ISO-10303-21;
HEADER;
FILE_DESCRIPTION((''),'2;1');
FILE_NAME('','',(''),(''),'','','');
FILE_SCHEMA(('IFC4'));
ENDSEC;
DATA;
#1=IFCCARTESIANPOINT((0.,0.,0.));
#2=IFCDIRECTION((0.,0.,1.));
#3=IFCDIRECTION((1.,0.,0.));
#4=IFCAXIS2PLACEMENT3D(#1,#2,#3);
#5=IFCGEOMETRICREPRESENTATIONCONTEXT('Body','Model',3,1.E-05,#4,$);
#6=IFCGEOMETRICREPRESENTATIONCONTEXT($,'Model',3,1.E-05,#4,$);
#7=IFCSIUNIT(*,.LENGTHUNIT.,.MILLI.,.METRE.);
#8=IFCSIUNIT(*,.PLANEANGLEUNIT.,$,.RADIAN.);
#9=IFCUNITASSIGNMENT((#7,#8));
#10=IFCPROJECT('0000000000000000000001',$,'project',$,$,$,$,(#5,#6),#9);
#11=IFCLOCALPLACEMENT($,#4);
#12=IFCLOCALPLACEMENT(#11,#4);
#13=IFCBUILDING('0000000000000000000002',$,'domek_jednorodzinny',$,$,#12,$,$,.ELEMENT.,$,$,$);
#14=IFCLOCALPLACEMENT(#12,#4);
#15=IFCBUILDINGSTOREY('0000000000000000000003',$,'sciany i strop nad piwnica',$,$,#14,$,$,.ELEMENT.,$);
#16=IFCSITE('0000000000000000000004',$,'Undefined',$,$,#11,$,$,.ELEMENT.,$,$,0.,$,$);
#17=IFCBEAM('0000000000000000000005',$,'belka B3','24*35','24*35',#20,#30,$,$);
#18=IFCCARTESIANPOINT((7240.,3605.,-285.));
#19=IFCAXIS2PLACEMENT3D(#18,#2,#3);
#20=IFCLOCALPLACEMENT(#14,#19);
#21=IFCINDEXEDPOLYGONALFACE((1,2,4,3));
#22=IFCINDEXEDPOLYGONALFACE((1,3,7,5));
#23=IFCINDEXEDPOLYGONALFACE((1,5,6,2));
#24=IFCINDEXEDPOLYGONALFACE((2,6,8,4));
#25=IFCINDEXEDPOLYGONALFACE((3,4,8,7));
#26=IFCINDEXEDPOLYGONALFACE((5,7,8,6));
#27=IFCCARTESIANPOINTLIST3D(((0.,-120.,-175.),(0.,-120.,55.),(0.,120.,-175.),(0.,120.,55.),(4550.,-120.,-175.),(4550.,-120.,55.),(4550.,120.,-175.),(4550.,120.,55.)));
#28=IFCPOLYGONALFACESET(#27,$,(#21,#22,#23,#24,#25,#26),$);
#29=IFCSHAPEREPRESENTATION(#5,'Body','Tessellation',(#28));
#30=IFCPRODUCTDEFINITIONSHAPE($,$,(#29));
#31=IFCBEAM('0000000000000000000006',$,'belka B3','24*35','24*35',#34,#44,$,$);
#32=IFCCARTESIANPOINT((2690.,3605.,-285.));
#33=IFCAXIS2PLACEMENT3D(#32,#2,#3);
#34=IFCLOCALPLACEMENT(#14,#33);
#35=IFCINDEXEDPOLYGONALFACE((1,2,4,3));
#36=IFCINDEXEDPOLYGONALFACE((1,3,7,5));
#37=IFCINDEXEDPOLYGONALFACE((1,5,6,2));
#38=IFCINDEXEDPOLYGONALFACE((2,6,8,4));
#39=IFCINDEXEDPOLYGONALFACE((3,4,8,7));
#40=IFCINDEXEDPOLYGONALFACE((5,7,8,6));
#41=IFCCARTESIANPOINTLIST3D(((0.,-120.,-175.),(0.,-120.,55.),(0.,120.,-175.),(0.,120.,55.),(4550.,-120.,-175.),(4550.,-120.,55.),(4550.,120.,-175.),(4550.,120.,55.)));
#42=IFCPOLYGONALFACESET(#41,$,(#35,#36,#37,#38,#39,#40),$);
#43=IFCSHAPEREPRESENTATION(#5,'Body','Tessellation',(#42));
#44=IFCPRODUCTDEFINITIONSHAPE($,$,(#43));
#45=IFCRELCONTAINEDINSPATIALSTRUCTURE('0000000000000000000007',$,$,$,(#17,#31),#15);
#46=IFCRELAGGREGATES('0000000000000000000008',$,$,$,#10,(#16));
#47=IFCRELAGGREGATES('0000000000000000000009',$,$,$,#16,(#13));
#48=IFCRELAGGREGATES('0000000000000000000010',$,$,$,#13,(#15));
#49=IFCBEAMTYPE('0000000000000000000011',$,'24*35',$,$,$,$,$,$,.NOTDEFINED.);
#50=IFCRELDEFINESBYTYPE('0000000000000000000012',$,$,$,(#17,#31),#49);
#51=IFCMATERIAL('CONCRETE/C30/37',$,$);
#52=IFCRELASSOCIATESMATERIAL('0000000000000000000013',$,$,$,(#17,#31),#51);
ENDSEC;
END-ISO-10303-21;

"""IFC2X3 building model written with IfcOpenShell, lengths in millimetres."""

from ifc_helpers import new_model, si_unit, frame, origin_with_axes, origin_2d_with_axis, place, context, project, spatial, rectangle, extrude, clip, halfspace, material, type_object, element, save


model = new_model("IFC2X3")

# Units and contexts
model_context_1 = context("Model", 3, precision=1e-05, world=origin_with_axes(), identifier="Body")
model_context_2 = context("Model", 3, precision=1e-05, world=origin_with_axes())
ifc_project = project(units=[si_unit("LENGTHUNIT", "METRE", prefix="MILLI"), si_unit("PLANEANGLEUNIT", "RADIAN")], contexts=[model_context_1, model_context_2])

# Site, building, storey
site_placement = place(None, origin_with_axes())
site = spatial("IfcSite", under=ifc_project, at=site_placement, Name="Undefined", CompositionType="ELEMENT", RefElevation=0.0)
building_placement = place(site_placement, origin_with_axes())
building = spatial("IfcBuilding", under=site, at=building_placement, Name="domek_jednorodzinny", CompositionType="ELEMENT")
storey_placement = place(building_placement, origin_with_axes())
storey = spatial("IfcBuildingStorey", under=building, at=storey_placement, Name="sciany i strop nad piwnica", CompositionType="ELEMENT")

# Shared definitions
ifc_material_1 = material(Name="CONCRETE/C30/37")

# Beams
beam_type_1 = type_object("IfcBeamType", Name="24*35", PredefinedType="NOTDEFINED")
beam_1_placement = place(storey_placement, frame((7240.0, 3605.0, -285.0), z_axis=(0.0, 0.0, 1.0), x_axis=(1.0, 0.0, 0.0)))
element("IfcBeam", 1, at=beam_1_placement, inside=storey, type_object=beam_type_1, material=ifc_material_1, Name="belka B3", Description="24*35", ObjectType="24*35", context=model_context_1, shape_type="Clipping", body=[
    clip(extrude(rectangle(XDim=240.0, YDim=350.0, at=origin_2d_with_axis()), frame((4550.0, 0.0, 0.0), z_axis=(-1.0, 0.0, 0.0), x_axis=(0.0, -1.0, 0.0)), (0.0, 0.0, 1.0), 4550.0), halfspace(frame((4550.0, 120.0, 55.0), z_axis=(0.0, 0.0, 1.0), x_axis=(0.0, -1.0, 0.0)), False)),
])
beam_2_placement = place(storey_placement, frame((2690.0, 3605.0, -285.0), z_axis=(0.0, 0.0, 1.0), x_axis=(1.0, 0.0, 0.0)))
element("IfcBeam", 2, at=beam_2_placement, inside=storey, type_object=beam_type_1, material=ifc_material_1, Name="belka B3", Description="24*35", ObjectType="24*35", context=model_context_1, shape_type="Clipping", body=[
    clip(extrude(rectangle(XDim=240.0, YDim=350.0, at=origin_2d_with_axis()), frame((4550.0, 0.0, 0.0), z_axis=(-1.0, 0.0, 0.0), x_axis=(0.0, -1.0, 0.0)), (0.0, 0.0, 1.0), 4550.0), halfspace(frame((4550.0, 120.0, 55.0), z_axis=(0.0, 0.0, 1.0), x_axis=(0.0, -1.0, 0.0)), False)),
])

save(model, "model.ifc")
